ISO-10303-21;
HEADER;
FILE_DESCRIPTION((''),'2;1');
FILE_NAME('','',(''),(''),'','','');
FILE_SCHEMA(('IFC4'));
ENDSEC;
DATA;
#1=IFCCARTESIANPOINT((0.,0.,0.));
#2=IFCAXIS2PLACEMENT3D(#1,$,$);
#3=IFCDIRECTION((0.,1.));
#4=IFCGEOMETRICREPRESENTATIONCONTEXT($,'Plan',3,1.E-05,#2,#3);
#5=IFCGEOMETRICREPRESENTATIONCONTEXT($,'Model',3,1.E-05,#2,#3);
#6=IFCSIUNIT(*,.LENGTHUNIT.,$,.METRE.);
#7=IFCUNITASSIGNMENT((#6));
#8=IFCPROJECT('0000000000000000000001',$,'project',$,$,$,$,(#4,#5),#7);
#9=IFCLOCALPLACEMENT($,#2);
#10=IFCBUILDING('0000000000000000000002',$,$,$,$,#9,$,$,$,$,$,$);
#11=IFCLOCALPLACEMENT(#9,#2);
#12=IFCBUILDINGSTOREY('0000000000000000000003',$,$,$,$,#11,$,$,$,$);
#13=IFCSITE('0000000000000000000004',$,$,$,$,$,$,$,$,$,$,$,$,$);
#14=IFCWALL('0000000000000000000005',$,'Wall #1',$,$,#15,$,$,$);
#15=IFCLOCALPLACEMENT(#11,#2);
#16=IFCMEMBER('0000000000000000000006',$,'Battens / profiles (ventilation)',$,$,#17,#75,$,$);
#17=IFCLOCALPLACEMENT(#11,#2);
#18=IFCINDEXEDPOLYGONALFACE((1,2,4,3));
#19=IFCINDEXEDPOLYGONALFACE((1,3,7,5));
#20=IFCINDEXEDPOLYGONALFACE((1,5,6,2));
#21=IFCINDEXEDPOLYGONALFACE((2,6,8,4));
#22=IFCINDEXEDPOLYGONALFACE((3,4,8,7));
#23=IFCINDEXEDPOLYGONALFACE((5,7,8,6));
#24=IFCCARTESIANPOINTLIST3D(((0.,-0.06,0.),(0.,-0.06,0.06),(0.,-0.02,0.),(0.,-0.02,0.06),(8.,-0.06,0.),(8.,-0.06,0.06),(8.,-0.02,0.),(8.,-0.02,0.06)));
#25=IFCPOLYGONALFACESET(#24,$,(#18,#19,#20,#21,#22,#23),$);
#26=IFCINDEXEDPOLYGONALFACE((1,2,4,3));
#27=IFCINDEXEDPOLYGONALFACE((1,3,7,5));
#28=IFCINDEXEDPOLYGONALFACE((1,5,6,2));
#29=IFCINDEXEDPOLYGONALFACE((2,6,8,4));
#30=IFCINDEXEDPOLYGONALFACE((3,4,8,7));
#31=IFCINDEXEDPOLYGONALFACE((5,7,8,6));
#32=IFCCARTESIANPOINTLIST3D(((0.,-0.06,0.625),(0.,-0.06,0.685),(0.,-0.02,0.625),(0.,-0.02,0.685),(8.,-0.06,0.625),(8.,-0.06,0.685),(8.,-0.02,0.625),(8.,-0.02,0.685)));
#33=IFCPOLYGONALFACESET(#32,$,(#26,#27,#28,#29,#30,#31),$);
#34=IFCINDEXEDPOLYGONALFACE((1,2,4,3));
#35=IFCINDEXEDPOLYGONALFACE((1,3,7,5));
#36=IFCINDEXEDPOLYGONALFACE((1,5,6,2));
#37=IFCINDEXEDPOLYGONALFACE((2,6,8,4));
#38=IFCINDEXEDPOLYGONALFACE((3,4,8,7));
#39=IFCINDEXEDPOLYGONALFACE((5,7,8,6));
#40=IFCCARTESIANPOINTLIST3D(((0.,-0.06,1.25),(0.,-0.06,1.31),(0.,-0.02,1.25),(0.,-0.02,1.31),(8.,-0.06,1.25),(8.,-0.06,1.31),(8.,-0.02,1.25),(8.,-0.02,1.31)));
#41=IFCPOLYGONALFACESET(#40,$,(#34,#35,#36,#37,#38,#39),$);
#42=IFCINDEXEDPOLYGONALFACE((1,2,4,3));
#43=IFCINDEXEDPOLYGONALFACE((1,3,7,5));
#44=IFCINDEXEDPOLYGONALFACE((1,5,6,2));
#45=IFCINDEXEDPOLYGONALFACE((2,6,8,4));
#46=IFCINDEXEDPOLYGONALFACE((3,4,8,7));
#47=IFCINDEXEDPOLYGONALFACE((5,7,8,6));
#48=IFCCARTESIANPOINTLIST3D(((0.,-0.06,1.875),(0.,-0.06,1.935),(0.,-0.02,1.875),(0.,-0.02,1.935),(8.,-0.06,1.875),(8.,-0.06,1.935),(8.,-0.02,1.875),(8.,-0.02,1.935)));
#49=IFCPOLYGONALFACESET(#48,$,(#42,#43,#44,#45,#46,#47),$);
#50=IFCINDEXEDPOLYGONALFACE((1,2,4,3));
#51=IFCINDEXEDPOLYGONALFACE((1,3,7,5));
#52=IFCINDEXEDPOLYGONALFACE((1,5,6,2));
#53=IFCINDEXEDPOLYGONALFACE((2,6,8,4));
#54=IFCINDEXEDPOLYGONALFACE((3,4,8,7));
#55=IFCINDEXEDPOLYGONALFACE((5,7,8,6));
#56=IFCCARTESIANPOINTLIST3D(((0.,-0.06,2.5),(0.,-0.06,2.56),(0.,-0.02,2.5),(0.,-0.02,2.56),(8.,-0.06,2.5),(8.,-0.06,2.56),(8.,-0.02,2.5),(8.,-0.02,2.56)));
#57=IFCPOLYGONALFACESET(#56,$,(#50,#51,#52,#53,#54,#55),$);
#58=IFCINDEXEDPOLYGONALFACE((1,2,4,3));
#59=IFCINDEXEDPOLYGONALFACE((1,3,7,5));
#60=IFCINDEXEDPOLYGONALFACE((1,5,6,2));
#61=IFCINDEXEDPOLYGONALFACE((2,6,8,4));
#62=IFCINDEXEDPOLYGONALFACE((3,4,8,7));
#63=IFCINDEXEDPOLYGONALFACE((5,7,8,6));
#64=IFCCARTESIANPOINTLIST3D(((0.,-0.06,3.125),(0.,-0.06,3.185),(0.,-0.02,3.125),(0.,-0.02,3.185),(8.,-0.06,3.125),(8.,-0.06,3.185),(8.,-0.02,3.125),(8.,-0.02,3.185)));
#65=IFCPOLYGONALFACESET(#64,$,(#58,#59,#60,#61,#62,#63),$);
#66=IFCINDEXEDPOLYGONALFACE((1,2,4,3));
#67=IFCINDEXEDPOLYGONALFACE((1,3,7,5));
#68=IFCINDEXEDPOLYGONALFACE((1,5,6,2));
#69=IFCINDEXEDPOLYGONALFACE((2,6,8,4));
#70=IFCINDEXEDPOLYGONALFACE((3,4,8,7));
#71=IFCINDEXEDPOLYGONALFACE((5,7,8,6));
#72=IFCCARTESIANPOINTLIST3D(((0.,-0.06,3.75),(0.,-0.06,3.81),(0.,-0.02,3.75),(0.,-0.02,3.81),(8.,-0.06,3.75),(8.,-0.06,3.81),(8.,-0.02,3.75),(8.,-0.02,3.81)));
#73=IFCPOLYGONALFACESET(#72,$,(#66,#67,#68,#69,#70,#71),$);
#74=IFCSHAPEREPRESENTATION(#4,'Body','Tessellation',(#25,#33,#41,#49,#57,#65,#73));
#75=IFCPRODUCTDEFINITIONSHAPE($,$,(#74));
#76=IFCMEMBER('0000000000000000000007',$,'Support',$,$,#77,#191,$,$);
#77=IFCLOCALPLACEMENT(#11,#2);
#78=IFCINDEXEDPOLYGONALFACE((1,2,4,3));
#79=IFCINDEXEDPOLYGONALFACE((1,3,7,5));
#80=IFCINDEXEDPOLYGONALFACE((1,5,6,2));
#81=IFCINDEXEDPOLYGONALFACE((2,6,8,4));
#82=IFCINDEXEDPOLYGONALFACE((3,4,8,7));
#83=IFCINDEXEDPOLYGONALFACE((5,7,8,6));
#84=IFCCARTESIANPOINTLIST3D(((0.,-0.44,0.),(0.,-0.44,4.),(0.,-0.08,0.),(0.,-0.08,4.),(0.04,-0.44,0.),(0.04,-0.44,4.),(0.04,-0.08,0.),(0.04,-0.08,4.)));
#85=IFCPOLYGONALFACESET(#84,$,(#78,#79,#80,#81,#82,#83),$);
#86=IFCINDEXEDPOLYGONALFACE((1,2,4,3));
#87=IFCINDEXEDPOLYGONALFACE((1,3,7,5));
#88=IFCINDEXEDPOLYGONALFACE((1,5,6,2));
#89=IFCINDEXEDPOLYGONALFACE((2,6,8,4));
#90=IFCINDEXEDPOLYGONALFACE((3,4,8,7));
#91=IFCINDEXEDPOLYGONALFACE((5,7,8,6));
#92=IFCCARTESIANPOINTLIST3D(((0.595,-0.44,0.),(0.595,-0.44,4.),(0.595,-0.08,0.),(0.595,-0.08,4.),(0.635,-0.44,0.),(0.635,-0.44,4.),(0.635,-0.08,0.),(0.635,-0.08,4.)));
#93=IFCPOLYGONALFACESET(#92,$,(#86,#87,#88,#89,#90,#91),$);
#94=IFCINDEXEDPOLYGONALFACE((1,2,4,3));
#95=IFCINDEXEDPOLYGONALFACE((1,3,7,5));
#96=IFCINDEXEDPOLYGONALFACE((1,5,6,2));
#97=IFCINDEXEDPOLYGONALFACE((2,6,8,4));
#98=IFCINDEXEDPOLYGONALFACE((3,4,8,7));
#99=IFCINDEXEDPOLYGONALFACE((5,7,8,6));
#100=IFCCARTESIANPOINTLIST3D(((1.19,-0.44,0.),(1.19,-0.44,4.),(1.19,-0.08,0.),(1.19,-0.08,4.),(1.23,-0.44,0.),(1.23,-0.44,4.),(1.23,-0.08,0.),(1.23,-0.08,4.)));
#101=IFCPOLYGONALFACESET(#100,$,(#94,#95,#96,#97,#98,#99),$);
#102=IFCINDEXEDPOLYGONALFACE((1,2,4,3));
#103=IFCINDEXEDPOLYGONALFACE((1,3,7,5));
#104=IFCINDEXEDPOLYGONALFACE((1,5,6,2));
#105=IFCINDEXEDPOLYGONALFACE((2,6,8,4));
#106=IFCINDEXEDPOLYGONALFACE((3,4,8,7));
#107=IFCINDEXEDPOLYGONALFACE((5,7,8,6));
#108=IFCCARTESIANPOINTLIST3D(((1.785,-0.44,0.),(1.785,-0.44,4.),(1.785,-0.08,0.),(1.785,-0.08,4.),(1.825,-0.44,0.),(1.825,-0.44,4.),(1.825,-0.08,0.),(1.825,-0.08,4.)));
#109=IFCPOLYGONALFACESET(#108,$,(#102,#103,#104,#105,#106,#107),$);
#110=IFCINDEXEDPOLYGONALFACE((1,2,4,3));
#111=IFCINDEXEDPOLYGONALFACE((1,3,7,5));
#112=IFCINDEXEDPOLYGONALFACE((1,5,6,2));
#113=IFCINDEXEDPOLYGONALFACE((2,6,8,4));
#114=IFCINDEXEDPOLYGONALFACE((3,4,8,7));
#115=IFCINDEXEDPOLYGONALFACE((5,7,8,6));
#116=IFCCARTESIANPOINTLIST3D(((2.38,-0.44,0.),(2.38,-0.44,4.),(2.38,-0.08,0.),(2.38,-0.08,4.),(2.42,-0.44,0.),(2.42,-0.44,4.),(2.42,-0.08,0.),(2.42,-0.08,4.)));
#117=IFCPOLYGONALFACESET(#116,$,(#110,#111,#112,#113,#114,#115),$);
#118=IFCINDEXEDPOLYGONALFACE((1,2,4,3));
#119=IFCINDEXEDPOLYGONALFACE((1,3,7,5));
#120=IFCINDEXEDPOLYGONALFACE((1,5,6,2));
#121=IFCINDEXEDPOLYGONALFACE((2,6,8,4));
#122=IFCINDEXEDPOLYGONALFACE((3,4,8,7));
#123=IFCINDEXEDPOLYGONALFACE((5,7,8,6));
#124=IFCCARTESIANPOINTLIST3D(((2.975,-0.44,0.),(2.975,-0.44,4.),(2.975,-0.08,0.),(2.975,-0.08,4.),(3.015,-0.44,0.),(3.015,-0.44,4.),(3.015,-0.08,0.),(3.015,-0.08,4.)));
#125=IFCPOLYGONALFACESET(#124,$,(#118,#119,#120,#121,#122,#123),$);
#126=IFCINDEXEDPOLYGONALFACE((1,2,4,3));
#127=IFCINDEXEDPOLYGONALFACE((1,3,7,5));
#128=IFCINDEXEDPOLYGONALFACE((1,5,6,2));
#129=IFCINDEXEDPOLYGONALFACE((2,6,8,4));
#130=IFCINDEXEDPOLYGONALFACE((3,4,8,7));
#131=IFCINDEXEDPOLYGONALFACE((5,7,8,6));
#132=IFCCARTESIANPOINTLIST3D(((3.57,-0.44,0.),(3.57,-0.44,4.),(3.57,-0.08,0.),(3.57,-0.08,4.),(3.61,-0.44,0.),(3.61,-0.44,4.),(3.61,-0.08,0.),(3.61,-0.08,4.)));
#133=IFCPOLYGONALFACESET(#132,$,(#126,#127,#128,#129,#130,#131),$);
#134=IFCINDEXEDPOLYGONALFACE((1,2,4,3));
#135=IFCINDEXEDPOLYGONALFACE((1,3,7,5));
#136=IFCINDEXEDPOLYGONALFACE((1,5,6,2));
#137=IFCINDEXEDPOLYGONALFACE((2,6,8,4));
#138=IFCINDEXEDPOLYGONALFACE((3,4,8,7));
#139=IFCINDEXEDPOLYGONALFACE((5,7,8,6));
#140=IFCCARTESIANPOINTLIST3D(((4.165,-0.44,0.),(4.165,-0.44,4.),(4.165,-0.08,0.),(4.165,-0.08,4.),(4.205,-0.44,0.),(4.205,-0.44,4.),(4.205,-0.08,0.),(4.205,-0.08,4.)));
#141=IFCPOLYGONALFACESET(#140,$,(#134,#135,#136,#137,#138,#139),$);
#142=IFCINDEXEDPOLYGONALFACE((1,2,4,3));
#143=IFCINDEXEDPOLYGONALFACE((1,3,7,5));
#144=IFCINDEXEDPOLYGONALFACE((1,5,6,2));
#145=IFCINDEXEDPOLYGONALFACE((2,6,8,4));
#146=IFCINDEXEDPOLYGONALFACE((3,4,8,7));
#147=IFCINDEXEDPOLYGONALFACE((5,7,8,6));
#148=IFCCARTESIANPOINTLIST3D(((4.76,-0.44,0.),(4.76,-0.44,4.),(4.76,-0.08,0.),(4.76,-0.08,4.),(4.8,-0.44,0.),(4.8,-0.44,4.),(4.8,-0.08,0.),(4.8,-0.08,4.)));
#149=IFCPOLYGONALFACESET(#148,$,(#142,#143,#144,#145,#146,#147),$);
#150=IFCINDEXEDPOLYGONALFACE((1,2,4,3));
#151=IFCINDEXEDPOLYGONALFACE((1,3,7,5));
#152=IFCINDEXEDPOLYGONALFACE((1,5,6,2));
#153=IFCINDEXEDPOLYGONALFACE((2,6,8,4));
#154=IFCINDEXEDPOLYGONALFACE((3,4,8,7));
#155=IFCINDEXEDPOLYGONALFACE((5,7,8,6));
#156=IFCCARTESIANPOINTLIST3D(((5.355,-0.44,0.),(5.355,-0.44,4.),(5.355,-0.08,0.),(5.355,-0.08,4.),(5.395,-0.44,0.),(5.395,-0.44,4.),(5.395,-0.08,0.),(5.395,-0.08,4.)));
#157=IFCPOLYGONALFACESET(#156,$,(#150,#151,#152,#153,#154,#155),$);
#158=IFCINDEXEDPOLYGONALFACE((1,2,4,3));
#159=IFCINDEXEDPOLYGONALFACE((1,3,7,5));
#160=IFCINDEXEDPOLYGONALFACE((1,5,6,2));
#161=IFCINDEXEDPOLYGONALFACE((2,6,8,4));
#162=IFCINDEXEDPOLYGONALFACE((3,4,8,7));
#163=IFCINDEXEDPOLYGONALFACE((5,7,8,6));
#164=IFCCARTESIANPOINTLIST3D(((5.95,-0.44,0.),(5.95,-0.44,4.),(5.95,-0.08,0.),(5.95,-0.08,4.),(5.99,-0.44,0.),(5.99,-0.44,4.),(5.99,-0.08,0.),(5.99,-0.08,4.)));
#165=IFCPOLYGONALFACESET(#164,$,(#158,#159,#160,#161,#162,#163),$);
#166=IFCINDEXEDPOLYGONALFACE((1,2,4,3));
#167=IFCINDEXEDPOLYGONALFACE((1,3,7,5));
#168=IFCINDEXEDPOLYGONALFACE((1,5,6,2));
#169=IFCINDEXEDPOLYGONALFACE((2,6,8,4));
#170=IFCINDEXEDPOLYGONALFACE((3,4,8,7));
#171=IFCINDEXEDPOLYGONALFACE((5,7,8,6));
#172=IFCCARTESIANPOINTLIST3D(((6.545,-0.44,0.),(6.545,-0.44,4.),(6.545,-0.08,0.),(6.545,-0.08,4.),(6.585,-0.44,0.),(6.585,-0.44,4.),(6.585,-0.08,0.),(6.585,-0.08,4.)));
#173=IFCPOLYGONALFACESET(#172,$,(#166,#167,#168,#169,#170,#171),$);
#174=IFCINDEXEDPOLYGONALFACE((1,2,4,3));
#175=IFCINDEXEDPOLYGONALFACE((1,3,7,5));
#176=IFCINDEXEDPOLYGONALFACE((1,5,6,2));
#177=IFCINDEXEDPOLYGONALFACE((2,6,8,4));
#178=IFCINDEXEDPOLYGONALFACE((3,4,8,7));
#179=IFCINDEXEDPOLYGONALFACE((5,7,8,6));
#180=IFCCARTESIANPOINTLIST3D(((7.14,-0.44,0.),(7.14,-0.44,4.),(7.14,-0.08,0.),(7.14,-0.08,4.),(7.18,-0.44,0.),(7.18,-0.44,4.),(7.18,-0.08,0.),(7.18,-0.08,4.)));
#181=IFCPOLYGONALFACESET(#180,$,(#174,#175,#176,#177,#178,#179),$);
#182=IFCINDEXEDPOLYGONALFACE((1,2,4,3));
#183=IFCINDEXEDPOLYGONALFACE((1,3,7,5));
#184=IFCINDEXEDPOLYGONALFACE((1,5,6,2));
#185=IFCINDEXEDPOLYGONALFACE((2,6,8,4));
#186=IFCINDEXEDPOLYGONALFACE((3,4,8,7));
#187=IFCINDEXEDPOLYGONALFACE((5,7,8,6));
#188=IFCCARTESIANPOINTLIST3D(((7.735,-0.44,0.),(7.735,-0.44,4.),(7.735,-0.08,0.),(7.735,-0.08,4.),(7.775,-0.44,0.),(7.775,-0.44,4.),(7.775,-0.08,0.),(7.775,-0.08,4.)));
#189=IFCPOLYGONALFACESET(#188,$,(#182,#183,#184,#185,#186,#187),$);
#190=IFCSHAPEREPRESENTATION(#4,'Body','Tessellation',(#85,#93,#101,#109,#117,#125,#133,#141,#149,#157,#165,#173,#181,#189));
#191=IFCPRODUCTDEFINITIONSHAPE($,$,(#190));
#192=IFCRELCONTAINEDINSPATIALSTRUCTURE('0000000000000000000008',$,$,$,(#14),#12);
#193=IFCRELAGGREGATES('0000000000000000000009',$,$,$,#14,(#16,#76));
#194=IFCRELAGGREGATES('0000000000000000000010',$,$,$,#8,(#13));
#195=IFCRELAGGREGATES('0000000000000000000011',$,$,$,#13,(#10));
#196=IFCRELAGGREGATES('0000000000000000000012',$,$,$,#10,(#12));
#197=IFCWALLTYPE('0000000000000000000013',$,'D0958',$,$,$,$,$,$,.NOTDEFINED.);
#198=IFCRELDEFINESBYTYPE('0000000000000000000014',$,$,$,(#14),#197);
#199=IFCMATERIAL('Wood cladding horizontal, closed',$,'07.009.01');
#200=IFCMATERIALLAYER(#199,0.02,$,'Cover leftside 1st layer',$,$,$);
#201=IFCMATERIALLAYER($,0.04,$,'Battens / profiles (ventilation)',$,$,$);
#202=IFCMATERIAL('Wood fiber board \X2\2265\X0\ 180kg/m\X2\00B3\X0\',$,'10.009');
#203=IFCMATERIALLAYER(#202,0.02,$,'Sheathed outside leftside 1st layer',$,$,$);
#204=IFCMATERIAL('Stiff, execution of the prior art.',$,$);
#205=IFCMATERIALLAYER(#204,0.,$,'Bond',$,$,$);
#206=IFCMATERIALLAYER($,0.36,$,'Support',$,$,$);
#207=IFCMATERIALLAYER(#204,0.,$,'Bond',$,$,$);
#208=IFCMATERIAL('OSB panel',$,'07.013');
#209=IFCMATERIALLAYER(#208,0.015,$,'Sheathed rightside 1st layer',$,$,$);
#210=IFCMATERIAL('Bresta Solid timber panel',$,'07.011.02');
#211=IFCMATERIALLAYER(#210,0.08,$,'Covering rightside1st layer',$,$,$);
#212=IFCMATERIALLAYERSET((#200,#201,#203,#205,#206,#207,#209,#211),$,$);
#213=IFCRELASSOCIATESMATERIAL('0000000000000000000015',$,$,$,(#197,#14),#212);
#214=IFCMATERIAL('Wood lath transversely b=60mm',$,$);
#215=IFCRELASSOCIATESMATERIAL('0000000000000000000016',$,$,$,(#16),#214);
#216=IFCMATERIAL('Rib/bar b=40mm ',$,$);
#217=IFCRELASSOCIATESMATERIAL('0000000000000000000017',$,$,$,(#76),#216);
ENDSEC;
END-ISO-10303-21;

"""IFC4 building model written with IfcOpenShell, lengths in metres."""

from ifc_helpers import new_model, si_unit, direction, frame, frame_2d, origin, place, context, project, spatial, rectangle, extrude, material, layer, layer_set, type_object, element, aggregate, save


model = new_model("IFC4")

# Units and contexts
plan_context = context("Plan", 3, precision=1e-05, world=origin(), true_north=direction((0.0, 1.0)))
model_context = context("Model", 3, precision=1e-05, world=origin(), true_north=direction((0.0, 1.0)))
ifc_project = project(units=[si_unit("LENGTHUNIT", "METRE")], contexts=[plan_context, model_context])

# Site, building, storey
site = spatial("IfcSite", under=ifc_project)
building_placement = place(None, origin())
building = spatial("IfcBuilding", under=site, at=building_placement)
storey_placement = place(building_placement, origin())
storey = spatial("IfcBuildingStorey", under=building, at=storey_placement)

# Wall, members
ifc_material_1 = material(Name="Wood cladding horizontal, closed", Category="07.009.01")
ifc_layer_1 = layer(ifc_material_1, 0.02, Name="Cover leftside 1st layer")
ifc_layer_2 = layer(None, 0.04, Name="Battens / profiles (ventilation)")
ifc_material_2 = material(Name="Wood fiber board ≥ 180kg/m³", Category="10.009")
ifc_layer_3 = layer(ifc_material_2, 0.02, Name="Sheathed outside leftside 1st layer")
ifc_material_3 = material(Name="Stiff, execution of the prior art.")
ifc_layer_4 = layer(ifc_material_3, 0.0, Name="Bond")
ifc_layer_5 = layer(None, 0.36, Name="Support")
ifc_layer_6 = layer(ifc_material_3, 0.0, Name="Bond")
ifc_material_4 = material(Name="OSB panel", Category="07.013")
ifc_layer_7 = layer(ifc_material_4, 0.015, Name="Sheathed rightside 1st layer")
ifc_material_5 = material(Name="Bresta Solid timber panel", Category="07.011.02")
ifc_layer_8 = layer(ifc_material_5, 0.08, Name="Covering rightside1st layer")
ifc_layer_set = layer_set([ifc_layer_1, ifc_layer_2, ifc_layer_3, ifc_layer_4, ifc_layer_5, ifc_layer_6, ifc_layer_7, ifc_layer_8])
wall_type = type_object("IfcWallType", Name="D0958", PredefinedType="NOTDEFINED", material=ifc_layer_set)
wall_placement = place(None, frame((0.0, 0.0, 0.0), z_axis=(0.0, -1.0, 0.0), x_axis=(1.0, 0.0, 0.0)))
wall = element("IfcWall", 1, at=wall_placement, inside=storey, type_object=wall_type, material=ifc_layer_set, Name="Wall #1")
ifc_material_6 = material(Name="Wood lath transversely b=60mm")
member_1_placement = place(wall_placement, origin())
member_1 = element("IfcMember", 2, at=member_1_placement, material=ifc_material_6, Name="Battens / profiles (ventilation)", context=plan_context, shape_type="SweptSolid", body=[
    extrude(rectangle(XDim=0.06, YDim=0.04, at=frame_2d((0.03, 0.02), x_axis=(1.0, 0.0))), frame((0.0, 0.0, 0.02), z_axis=(1.0, 0.0, 0.0), x_axis=(0.0, 1.0, 0.0)), (0.0, 0.0, 1.0), 8.0),
    extrude(rectangle(XDim=0.06, YDim=0.04, at=frame_2d((0.03, 0.02), x_axis=(1.0, 0.0))), frame((0.0, 0.625, 0.02), z_axis=(1.0, 0.0, 0.0), x_axis=(0.0, 1.0, 0.0)), (0.0, 0.0, 1.0), 8.0),
    extrude(rectangle(XDim=0.06, YDim=0.04, at=frame_2d((0.03, 0.02), x_axis=(1.0, 0.0))), frame((0.0, 1.25, 0.02), z_axis=(1.0, 0.0, 0.0), x_axis=(0.0, 1.0, 0.0)), (0.0, 0.0, 1.0), 8.0),
    extrude(rectangle(XDim=0.06, YDim=0.04, at=frame_2d((0.03, 0.02), x_axis=(1.0, 0.0))), frame((0.0, 1.875, 0.02), z_axis=(1.0, 0.0, 0.0), x_axis=(0.0, 1.0, 0.0)), (0.0, 0.0, 1.0), 8.0),
    extrude(rectangle(XDim=0.06, YDim=0.04, at=frame_2d((0.03, 0.02), x_axis=(1.0, 0.0))), frame((0.0, 2.5, 0.02), z_axis=(1.0, 0.0, 0.0), x_axis=(0.0, 1.0, 0.0)), (0.0, 0.0, 1.0), 8.0),
    extrude(rectangle(XDim=0.06, YDim=0.04, at=frame_2d((0.03, 0.02), x_axis=(1.0, 0.0))), frame((0.0, 3.125, 0.02), z_axis=(1.0, 0.0, 0.0), x_axis=(0.0, 1.0, 0.0)), (0.0, 0.0, 1.0), 8.0),
    extrude(rectangle(XDim=0.06, YDim=0.04, at=frame_2d((0.03, 0.02), x_axis=(1.0, 0.0))), frame((0.0, 3.75, 0.02), z_axis=(1.0, 0.0, 0.0), x_axis=(0.0, 1.0, 0.0)), (0.0, 0.0, 1.0), 8.0),
])
ifc_material_7 = material(Name="Rib/bar b=40mm ")
member_2_placement = place(wall_placement, origin())
member_2 = element("IfcMember", 3, at=member_2_placement, material=ifc_material_7, Name="Support", context=plan_context, shape_type="SweptSolid", body=[
    extrude(rectangle(XDim=0.04, YDim=0.36, at=frame_2d((0.02, 0.18), x_axis=(1.0, 0.0))), frame((0.0, 4.0, 0.08), z_axis=(0.0, -1.0, 0.0), x_axis=(1.0, 0.0, 0.0)), (0.0, 0.0, 1.0), 4.0),
    extrude(rectangle(XDim=0.04, YDim=0.36, at=frame_2d((0.02, 0.18), x_axis=(1.0, 0.0))), frame((0.595, 4.0, 0.08), z_axis=(0.0, -1.0, 0.0), x_axis=(1.0, 0.0, 0.0)), (0.0, 0.0, 1.0), 4.0),
    extrude(rectangle(XDim=0.04, YDim=0.36, at=frame_2d((0.02, 0.18), x_axis=(1.0, 0.0))), frame((1.19, 4.0, 0.08), z_axis=(0.0, -1.0, 0.0), x_axis=(1.0, 0.0, 0.0)), (0.0, 0.0, 1.0), 4.0),
    extrude(rectangle(XDim=0.04, YDim=0.36, at=frame_2d((0.02, 0.18), x_axis=(1.0, 0.0))), frame((1.785, 4.0, 0.08), z_axis=(0.0, -1.0, 0.0), x_axis=(1.0, 0.0, 0.0)), (0.0, 0.0, 1.0), 4.0),
    extrude(rectangle(XDim=0.04, YDim=0.36, at=frame_2d((0.02, 0.18), x_axis=(1.0, 0.0))), frame((2.38, 4.0, 0.08), z_axis=(0.0, -1.0, 0.0), x_axis=(1.0, 0.0, 0.0)), (0.0, 0.0, 1.0), 4.0),
    extrude(rectangle(XDim=0.04, YDim=0.36, at=frame_2d((0.02, 0.18), x_axis=(1.0, 0.0))), frame((2.975, 4.0, 0.08), z_axis=(0.0, -1.0, 0.0), x_axis=(1.0, 0.0, 0.0)), (0.0, 0.0, 1.0), 4.0),
    extrude(rectangle(XDim=0.04, YDim=0.36, at=frame_2d((0.02, 0.18), x_axis=(1.0, 0.0))), frame((3.57, 4.0, 0.08), z_axis=(0.0, -1.0, 0.0), x_axis=(1.0, 0.0, 0.0)), (0.0, 0.0, 1.0), 4.0),
    extrude(rectangle(XDim=0.04, YDim=0.36, at=frame_2d((0.02, 0.18), x_axis=(1.0, 0.0))), frame((4.165, 4.0, 0.08), z_axis=(0.0, -1.0, 0.0), x_axis=(1.0, 0.0, 0.0)), (0.0, 0.0, 1.0), 4.0),
    extrude(rectangle(XDim=0.04, YDim=0.36, at=frame_2d((0.02, 0.18), x_axis=(1.0, 0.0))), frame((4.76, 4.0, 0.08), z_axis=(0.0, -1.0, 0.0), x_axis=(1.0, 0.0, 0.0)), (0.0, 0.0, 1.0), 4.0),
    extrude(rectangle(XDim=0.04, YDim=0.36, at=frame_2d((0.02, 0.18), x_axis=(1.0, 0.0))), frame((5.355, 4.0, 0.08), z_axis=(0.0, -1.0, 0.0), x_axis=(1.0, 0.0, 0.0)), (0.0, 0.0, 1.0), 4.0),
    extrude(rectangle(XDim=0.04, YDim=0.36, at=frame_2d((0.02, 0.18), x_axis=(1.0, 0.0))), frame((5.95, 4.0, 0.08), z_axis=(0.0, -1.0, 0.0), x_axis=(1.0, 0.0, 0.0)), (0.0, 0.0, 1.0), 4.0),
    extrude(rectangle(XDim=0.04, YDim=0.36, at=frame_2d((0.02, 0.18), x_axis=(1.0, 0.0))), frame((6.545, 4.0, 0.08), z_axis=(0.0, -1.0, 0.0), x_axis=(1.0, 0.0, 0.0)), (0.0, 0.0, 1.0), 4.0),
    extrude(rectangle(XDim=0.04, YDim=0.36, at=frame_2d((0.02, 0.18), x_axis=(1.0, 0.0))), frame((7.14, 4.0, 0.08), z_axis=(0.0, -1.0, 0.0), x_axis=(1.0, 0.0, 0.0)), (0.0, 0.0, 1.0), 4.0),
    extrude(rectangle(XDim=0.04, YDim=0.36, at=frame_2d((0.02, 0.18), x_axis=(1.0, 0.0))), frame((7.735, 4.0, 0.08), z_axis=(0.0, -1.0, 0.0), x_axis=(1.0, 0.0, 0.0)), (0.0, 0.0, 1.0), 4.0),
])
aggregate(wall, [member_1, member_2])

save(model, "model.ifc")
